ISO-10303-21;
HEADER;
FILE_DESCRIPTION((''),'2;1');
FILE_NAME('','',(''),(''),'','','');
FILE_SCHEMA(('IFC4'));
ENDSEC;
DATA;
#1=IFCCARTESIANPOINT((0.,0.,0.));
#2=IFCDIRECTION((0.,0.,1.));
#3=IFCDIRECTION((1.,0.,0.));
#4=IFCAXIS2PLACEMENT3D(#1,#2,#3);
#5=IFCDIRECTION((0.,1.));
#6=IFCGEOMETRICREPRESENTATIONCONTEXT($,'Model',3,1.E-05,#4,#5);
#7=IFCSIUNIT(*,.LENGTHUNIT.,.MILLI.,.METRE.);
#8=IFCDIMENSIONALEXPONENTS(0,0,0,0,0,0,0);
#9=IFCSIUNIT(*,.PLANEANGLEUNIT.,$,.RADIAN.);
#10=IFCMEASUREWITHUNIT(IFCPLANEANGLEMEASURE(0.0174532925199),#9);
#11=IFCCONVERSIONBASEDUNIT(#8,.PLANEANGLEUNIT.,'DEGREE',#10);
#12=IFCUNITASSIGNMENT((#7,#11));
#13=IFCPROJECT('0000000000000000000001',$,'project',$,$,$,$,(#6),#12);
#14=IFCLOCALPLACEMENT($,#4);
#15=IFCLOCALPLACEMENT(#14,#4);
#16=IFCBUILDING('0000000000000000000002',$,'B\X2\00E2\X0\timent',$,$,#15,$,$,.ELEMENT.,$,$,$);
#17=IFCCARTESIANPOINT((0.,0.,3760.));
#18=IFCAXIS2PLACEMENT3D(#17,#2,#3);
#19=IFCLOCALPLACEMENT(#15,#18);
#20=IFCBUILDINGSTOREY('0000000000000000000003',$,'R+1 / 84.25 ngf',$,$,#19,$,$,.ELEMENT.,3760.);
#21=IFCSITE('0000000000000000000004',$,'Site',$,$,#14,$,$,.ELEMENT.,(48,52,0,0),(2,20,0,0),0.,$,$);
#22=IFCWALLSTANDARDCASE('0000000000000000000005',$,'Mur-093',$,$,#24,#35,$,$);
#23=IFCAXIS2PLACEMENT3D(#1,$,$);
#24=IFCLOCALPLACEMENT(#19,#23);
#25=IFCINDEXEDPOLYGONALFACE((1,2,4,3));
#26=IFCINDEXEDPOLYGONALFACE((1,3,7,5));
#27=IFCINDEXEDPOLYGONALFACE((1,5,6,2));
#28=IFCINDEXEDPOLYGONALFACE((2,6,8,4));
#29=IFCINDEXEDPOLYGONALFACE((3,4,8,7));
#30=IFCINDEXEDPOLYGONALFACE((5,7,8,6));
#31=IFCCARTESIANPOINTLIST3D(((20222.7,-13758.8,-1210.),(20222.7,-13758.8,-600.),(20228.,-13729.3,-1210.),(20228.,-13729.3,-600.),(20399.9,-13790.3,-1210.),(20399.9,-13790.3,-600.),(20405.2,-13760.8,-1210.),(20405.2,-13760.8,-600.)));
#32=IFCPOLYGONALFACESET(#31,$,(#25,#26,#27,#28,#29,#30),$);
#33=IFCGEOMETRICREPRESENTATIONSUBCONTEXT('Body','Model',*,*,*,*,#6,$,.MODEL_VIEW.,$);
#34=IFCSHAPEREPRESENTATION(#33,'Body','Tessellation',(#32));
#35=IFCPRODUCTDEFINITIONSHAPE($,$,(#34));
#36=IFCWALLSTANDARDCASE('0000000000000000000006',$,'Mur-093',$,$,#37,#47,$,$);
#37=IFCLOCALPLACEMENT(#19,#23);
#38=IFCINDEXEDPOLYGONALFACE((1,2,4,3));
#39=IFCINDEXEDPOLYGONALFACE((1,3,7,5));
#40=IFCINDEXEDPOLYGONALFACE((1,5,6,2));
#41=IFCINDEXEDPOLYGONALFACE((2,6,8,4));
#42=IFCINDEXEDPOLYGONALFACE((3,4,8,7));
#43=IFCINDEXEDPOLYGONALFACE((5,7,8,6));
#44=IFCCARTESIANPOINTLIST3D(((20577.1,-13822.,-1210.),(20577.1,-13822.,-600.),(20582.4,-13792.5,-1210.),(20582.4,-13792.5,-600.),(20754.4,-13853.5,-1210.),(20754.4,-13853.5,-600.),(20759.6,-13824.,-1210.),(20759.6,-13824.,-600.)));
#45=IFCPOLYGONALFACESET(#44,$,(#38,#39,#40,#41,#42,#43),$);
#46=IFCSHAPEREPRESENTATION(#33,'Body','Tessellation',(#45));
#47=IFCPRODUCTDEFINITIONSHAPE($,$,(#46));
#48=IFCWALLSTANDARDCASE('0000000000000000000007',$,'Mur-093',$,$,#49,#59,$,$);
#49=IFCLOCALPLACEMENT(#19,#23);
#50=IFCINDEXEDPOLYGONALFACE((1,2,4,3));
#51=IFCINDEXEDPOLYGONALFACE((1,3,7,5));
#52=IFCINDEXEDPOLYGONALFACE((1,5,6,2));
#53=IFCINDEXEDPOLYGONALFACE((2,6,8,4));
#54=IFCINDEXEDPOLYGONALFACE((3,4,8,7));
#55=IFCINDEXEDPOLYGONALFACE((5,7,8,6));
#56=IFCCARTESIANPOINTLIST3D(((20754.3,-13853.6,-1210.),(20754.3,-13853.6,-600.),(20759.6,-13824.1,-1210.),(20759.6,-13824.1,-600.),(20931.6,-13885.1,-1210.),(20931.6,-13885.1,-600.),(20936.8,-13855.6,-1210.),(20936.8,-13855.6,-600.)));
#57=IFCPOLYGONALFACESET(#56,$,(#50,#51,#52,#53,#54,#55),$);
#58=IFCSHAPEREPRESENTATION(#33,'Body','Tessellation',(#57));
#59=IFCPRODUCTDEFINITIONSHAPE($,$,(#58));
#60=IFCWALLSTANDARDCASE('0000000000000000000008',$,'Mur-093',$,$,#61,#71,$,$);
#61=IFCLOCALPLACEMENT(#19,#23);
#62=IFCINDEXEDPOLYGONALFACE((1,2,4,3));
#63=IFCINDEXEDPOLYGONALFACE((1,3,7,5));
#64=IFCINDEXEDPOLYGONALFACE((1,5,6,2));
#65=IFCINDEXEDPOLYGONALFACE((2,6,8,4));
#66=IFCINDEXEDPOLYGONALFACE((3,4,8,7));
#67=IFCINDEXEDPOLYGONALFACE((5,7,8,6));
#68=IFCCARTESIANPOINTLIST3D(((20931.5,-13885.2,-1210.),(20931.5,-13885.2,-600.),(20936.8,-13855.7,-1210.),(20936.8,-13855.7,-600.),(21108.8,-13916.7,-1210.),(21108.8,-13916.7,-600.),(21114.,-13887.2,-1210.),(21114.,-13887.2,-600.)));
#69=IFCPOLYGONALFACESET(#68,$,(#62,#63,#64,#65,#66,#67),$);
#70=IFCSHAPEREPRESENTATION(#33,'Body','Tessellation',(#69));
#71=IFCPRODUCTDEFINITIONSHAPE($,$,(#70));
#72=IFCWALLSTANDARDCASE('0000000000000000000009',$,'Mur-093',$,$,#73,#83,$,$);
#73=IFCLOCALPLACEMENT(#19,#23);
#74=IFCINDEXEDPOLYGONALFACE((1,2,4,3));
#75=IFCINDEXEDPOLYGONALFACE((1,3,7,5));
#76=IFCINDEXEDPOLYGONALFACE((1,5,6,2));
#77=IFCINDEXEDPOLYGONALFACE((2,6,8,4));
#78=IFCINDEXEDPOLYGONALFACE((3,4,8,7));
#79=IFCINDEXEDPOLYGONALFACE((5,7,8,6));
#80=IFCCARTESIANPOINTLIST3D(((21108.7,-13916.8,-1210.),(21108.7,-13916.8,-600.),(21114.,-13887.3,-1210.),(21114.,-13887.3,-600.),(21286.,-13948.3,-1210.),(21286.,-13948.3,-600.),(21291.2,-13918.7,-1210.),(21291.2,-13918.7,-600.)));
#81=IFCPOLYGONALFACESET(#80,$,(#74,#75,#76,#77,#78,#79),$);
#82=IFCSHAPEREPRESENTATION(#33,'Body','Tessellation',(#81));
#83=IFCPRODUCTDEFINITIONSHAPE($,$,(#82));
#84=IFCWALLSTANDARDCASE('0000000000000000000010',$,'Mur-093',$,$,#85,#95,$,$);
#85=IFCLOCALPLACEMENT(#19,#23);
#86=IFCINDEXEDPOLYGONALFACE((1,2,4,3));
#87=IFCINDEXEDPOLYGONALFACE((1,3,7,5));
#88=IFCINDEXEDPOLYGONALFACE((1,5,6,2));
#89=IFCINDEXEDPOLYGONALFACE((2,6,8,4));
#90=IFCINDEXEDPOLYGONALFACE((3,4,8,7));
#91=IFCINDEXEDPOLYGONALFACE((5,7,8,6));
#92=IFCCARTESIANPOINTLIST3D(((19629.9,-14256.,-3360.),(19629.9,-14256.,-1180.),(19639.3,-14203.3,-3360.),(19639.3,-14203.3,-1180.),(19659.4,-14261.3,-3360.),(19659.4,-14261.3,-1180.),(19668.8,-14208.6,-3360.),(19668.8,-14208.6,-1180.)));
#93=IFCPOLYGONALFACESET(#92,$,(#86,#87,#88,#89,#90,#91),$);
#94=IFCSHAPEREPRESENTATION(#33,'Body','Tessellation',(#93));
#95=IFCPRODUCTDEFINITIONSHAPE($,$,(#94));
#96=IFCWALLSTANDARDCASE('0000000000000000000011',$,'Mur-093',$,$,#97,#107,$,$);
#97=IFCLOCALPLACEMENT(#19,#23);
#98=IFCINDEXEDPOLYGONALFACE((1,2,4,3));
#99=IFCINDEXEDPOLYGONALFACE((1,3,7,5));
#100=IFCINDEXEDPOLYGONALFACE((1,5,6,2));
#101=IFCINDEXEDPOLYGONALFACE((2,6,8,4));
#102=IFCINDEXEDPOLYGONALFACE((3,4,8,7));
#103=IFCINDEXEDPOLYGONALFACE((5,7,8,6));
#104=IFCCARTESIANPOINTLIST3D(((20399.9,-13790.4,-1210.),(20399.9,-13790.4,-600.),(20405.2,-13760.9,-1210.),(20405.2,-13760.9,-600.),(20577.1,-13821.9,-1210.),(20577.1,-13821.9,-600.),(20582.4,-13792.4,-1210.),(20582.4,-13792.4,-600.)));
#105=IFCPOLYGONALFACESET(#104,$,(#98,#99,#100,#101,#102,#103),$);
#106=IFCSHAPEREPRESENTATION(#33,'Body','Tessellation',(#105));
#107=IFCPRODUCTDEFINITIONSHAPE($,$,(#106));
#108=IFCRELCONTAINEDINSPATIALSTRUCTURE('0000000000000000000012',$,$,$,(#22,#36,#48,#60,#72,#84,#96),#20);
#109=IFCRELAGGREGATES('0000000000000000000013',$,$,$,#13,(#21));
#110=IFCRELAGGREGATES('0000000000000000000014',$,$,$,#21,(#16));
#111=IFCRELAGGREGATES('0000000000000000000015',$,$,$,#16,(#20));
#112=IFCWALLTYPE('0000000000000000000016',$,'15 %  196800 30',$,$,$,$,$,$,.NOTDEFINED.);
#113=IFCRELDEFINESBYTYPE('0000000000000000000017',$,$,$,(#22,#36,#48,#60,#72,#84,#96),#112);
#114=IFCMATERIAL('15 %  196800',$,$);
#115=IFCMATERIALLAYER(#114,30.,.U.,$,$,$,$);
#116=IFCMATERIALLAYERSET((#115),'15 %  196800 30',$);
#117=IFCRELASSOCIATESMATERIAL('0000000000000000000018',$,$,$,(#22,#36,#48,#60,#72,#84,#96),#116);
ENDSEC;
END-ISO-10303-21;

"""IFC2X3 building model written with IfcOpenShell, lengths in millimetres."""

from ifc_helpers import new_model, entity, si_unit, converted_unit, direction, frame, origin_with_axes, place, context, subcontext, project, spatial, polyline, outline, extrude, material, layer, layer_set, layer_usage, type_object, element, save


model = new_model("IFC2X3")

# Units and contexts
model_context = context("Model", 3, precision=1e-05, world=origin_with_axes(), true_north=direction((0.0, 1.0)))
body_context = subcontext(model_context, "Body", "Model", "MODEL_VIEW")
ifc_project = project(units=[si_unit("LENGTHUNIT", "METRE", prefix="MILLI"), converted_unit("PLANEANGLEUNIT", "DEGREE", entity("IfcPlaneAngleMeasure", 0.0174532925199), si_unit("PLANEANGLEUNIT", "RADIAN"), dimensions=[0, 0, 0, 0, 0, 0, 0])], contexts=[model_context])

# Site, building, storey
site_placement = place(None, origin_with_axes())
site = spatial("IfcSite", under=ifc_project, at=site_placement, Name="Site", CompositionType="ELEMENT", RefLatitude=(48, 52, 0, 0), RefLongitude=(2, 20, 0, 0), RefElevation=0.0)
building_placement = place(site_placement, origin_with_axes())
building = spatial("IfcBuilding", under=site, at=building_placement, Name="Bâtiment", CompositionType="ELEMENT")
storey_placement = place(building_placement, frame((0.0, 0.0, 3760.0), z_axis=(0.0, 0.0, 1.0), x_axis=(1.0, 0.0, 0.0)))
storey = spatial("IfcBuildingStorey", under=building, at=storey_placement, Name="R+1 / 84.25 ngf", CompositionType="ELEMENT", Elevation=3760.0)

# Shared definitions
ifc_material = material(Name="15 %  196800")
ifc_layer = layer(ifc_material, 30.0, ventilated="UNKNOWN")
ifc_layer_set = layer_set([ifc_layer], Name="15 %  196800 30")

# Walls
wall_type = type_object("IfcWallType", Name="15 %  196800 30", PredefinedType="NOTDEFINED")
ifc_layer_usage_1 = layer_usage(ifc_layer_set, "AXIS2", "NEGATIVE", 30.0)
wall_1_placement = place(storey_placement, frame((20405.2, -13760.8, -1210.0), z_axis=(0.0, 0.0, 1.0), x_axis=(-0.984592, 0.174869, 0.0)))
element("IfcWallStandardCase", 1, at=wall_1_placement, inside=storey, type_object=wall_type, material=ifc_layer_usage_1, Name="Mur-093", context=body_context, shape_type="SweptSolid", body=[
    extrude(outline(polyline([(0.0, 0.0), (180.0, 0.0), (180.0, 30.0), (0.0, 30.0), (0.0, 0.0)])), origin_with_axes(), (0.0, 0.0, 1.0), 610.0),
])
ifc_layer_usage_2 = layer_usage(ifc_layer_set, "AXIS2", "NEGATIVE", 30.0)
wall_2_placement = place(storey_placement, frame((20759.6, -13824.0, -1210.0), z_axis=(0.0, 0.0, 1.0), x_axis=(-0.984592, 0.174869, 0.0)))
element("IfcWallStandardCase", 2, at=wall_2_placement, inside=storey, type_object=wall_type, material=ifc_layer_usage_2, Name="Mur-093", context=body_context, shape_type="SweptSolid", body=[
    extrude(outline(polyline([(0.0, 0.0), (180.0, 0.0), (180.0, 30.0), (0.0, 30.0), (0.0, 0.0)])), origin_with_axes(), (0.0, 0.0, 1.0), 610.0),
])
ifc_layer_usage_3 = layer_usage(ifc_layer_set, "AXIS2", "NEGATIVE", 30.0)
wall_3_placement = place(storey_placement, frame((20936.8, -13855.6, -1210.0), z_axis=(0.0, 0.0, 1.0), x_axis=(-0.984592, 0.174869, 0.0)))
element("IfcWallStandardCase", 3, at=wall_3_placement, inside=storey, type_object=wall_type, material=ifc_layer_usage_3, Name="Mur-093", context=body_context, shape_type="SweptSolid", body=[
    extrude(outline(polyline([(0.0, 0.0), (180.0, 0.0), (180.0, 30.0), (0.0, 30.0), (0.0, 0.0)])), origin_with_axes(), (0.0, 0.0, 1.0), 610.0),
])
ifc_layer_usage_4 = layer_usage(ifc_layer_set, "AXIS2", "NEGATIVE", 30.0)
wall_4_placement = place(storey_placement, frame((21114.0, -13887.2, -1210.0), z_axis=(0.0, 0.0, 1.0), x_axis=(-0.984592, 0.174869, 0.0)))
element("IfcWallStandardCase", 4, at=wall_4_placement, inside=storey, type_object=wall_type, material=ifc_layer_usage_4, Name="Mur-093", context=body_context, shape_type="SweptSolid", body=[
    extrude(outline(polyline([(0.0, 0.0), (180.0, 0.0), (180.0, 30.0), (0.0, 30.0), (0.0, 0.0)])), origin_with_axes(), (0.0, 0.0, 1.0), 610.0),
])
ifc_layer_usage_5 = layer_usage(ifc_layer_set, "AXIS2", "NEGATIVE", 30.0)
wall_5_placement = place(storey_placement, frame((21291.2, -13918.7, -1210.0), z_axis=(0.0, 0.0, 1.0), x_axis=(-0.984592, 0.174869, 0.0)))
element("IfcWallStandardCase", 5, at=wall_5_placement, inside=storey, type_object=wall_type, material=ifc_layer_usage_5, Name="Mur-093", context=body_context, shape_type="SweptSolid", body=[
    extrude(outline(polyline([(0.0, 0.0), (180.0, 0.0), (180.0, 30.0), (0.0, 30.0), (0.0, 0.0)])), origin_with_axes(), (0.0, 0.0, 1.0), 610.0),
])
ifc_layer_usage_6 = layer_usage(ifc_layer_set, "AXIS2", "POSITIVE", -30.0)
wall_6_placement = place(storey_placement, frame((19668.8, -14208.6, -3360.0), z_axis=(0.0, 0.0, 1.0), x_axis=(-0.176462, -0.984308, 0.0)))
element("IfcWallStandardCase", 6, at=wall_6_placement, inside=storey, type_object=wall_type, material=ifc_layer_usage_6, Name="Mur-093", context=body_context, shape_type="SweptSolid", body=[
    extrude(outline(polyline([(0.0, -30.0), (53.5, -30.0), (53.5, 0.0), (0.0, 0.0), (0.0, -30.0)])), origin_with_axes(), (0.0, 0.0, 1.0), 2180.0),
])
ifc_layer_usage_7 = layer_usage(ifc_layer_set, "AXIS2", "NEGATIVE", 30.0)
wall_7_placement = place(storey_placement, frame((20582.4, -13792.4, -1210.0), z_axis=(0.0, 0.0, 1.0), x_axis=(-0.984592, 0.174869, 0.0)))
element("IfcWallStandardCase", 7, at=wall_7_placement, inside=storey, type_object=wall_type, material=ifc_layer_usage_7, Name="Mur-093", context=body_context, shape_type="SweptSolid", body=[
    extrude(outline(polyline([(0.0, 0.0), (180.0, 0.0), (180.0, 30.0), (0.0, 30.0), (0.0, 0.0)])), origin_with_axes(), (0.0, 0.0, 1.0), 610.0),
])

save(model, "model.ifc")
